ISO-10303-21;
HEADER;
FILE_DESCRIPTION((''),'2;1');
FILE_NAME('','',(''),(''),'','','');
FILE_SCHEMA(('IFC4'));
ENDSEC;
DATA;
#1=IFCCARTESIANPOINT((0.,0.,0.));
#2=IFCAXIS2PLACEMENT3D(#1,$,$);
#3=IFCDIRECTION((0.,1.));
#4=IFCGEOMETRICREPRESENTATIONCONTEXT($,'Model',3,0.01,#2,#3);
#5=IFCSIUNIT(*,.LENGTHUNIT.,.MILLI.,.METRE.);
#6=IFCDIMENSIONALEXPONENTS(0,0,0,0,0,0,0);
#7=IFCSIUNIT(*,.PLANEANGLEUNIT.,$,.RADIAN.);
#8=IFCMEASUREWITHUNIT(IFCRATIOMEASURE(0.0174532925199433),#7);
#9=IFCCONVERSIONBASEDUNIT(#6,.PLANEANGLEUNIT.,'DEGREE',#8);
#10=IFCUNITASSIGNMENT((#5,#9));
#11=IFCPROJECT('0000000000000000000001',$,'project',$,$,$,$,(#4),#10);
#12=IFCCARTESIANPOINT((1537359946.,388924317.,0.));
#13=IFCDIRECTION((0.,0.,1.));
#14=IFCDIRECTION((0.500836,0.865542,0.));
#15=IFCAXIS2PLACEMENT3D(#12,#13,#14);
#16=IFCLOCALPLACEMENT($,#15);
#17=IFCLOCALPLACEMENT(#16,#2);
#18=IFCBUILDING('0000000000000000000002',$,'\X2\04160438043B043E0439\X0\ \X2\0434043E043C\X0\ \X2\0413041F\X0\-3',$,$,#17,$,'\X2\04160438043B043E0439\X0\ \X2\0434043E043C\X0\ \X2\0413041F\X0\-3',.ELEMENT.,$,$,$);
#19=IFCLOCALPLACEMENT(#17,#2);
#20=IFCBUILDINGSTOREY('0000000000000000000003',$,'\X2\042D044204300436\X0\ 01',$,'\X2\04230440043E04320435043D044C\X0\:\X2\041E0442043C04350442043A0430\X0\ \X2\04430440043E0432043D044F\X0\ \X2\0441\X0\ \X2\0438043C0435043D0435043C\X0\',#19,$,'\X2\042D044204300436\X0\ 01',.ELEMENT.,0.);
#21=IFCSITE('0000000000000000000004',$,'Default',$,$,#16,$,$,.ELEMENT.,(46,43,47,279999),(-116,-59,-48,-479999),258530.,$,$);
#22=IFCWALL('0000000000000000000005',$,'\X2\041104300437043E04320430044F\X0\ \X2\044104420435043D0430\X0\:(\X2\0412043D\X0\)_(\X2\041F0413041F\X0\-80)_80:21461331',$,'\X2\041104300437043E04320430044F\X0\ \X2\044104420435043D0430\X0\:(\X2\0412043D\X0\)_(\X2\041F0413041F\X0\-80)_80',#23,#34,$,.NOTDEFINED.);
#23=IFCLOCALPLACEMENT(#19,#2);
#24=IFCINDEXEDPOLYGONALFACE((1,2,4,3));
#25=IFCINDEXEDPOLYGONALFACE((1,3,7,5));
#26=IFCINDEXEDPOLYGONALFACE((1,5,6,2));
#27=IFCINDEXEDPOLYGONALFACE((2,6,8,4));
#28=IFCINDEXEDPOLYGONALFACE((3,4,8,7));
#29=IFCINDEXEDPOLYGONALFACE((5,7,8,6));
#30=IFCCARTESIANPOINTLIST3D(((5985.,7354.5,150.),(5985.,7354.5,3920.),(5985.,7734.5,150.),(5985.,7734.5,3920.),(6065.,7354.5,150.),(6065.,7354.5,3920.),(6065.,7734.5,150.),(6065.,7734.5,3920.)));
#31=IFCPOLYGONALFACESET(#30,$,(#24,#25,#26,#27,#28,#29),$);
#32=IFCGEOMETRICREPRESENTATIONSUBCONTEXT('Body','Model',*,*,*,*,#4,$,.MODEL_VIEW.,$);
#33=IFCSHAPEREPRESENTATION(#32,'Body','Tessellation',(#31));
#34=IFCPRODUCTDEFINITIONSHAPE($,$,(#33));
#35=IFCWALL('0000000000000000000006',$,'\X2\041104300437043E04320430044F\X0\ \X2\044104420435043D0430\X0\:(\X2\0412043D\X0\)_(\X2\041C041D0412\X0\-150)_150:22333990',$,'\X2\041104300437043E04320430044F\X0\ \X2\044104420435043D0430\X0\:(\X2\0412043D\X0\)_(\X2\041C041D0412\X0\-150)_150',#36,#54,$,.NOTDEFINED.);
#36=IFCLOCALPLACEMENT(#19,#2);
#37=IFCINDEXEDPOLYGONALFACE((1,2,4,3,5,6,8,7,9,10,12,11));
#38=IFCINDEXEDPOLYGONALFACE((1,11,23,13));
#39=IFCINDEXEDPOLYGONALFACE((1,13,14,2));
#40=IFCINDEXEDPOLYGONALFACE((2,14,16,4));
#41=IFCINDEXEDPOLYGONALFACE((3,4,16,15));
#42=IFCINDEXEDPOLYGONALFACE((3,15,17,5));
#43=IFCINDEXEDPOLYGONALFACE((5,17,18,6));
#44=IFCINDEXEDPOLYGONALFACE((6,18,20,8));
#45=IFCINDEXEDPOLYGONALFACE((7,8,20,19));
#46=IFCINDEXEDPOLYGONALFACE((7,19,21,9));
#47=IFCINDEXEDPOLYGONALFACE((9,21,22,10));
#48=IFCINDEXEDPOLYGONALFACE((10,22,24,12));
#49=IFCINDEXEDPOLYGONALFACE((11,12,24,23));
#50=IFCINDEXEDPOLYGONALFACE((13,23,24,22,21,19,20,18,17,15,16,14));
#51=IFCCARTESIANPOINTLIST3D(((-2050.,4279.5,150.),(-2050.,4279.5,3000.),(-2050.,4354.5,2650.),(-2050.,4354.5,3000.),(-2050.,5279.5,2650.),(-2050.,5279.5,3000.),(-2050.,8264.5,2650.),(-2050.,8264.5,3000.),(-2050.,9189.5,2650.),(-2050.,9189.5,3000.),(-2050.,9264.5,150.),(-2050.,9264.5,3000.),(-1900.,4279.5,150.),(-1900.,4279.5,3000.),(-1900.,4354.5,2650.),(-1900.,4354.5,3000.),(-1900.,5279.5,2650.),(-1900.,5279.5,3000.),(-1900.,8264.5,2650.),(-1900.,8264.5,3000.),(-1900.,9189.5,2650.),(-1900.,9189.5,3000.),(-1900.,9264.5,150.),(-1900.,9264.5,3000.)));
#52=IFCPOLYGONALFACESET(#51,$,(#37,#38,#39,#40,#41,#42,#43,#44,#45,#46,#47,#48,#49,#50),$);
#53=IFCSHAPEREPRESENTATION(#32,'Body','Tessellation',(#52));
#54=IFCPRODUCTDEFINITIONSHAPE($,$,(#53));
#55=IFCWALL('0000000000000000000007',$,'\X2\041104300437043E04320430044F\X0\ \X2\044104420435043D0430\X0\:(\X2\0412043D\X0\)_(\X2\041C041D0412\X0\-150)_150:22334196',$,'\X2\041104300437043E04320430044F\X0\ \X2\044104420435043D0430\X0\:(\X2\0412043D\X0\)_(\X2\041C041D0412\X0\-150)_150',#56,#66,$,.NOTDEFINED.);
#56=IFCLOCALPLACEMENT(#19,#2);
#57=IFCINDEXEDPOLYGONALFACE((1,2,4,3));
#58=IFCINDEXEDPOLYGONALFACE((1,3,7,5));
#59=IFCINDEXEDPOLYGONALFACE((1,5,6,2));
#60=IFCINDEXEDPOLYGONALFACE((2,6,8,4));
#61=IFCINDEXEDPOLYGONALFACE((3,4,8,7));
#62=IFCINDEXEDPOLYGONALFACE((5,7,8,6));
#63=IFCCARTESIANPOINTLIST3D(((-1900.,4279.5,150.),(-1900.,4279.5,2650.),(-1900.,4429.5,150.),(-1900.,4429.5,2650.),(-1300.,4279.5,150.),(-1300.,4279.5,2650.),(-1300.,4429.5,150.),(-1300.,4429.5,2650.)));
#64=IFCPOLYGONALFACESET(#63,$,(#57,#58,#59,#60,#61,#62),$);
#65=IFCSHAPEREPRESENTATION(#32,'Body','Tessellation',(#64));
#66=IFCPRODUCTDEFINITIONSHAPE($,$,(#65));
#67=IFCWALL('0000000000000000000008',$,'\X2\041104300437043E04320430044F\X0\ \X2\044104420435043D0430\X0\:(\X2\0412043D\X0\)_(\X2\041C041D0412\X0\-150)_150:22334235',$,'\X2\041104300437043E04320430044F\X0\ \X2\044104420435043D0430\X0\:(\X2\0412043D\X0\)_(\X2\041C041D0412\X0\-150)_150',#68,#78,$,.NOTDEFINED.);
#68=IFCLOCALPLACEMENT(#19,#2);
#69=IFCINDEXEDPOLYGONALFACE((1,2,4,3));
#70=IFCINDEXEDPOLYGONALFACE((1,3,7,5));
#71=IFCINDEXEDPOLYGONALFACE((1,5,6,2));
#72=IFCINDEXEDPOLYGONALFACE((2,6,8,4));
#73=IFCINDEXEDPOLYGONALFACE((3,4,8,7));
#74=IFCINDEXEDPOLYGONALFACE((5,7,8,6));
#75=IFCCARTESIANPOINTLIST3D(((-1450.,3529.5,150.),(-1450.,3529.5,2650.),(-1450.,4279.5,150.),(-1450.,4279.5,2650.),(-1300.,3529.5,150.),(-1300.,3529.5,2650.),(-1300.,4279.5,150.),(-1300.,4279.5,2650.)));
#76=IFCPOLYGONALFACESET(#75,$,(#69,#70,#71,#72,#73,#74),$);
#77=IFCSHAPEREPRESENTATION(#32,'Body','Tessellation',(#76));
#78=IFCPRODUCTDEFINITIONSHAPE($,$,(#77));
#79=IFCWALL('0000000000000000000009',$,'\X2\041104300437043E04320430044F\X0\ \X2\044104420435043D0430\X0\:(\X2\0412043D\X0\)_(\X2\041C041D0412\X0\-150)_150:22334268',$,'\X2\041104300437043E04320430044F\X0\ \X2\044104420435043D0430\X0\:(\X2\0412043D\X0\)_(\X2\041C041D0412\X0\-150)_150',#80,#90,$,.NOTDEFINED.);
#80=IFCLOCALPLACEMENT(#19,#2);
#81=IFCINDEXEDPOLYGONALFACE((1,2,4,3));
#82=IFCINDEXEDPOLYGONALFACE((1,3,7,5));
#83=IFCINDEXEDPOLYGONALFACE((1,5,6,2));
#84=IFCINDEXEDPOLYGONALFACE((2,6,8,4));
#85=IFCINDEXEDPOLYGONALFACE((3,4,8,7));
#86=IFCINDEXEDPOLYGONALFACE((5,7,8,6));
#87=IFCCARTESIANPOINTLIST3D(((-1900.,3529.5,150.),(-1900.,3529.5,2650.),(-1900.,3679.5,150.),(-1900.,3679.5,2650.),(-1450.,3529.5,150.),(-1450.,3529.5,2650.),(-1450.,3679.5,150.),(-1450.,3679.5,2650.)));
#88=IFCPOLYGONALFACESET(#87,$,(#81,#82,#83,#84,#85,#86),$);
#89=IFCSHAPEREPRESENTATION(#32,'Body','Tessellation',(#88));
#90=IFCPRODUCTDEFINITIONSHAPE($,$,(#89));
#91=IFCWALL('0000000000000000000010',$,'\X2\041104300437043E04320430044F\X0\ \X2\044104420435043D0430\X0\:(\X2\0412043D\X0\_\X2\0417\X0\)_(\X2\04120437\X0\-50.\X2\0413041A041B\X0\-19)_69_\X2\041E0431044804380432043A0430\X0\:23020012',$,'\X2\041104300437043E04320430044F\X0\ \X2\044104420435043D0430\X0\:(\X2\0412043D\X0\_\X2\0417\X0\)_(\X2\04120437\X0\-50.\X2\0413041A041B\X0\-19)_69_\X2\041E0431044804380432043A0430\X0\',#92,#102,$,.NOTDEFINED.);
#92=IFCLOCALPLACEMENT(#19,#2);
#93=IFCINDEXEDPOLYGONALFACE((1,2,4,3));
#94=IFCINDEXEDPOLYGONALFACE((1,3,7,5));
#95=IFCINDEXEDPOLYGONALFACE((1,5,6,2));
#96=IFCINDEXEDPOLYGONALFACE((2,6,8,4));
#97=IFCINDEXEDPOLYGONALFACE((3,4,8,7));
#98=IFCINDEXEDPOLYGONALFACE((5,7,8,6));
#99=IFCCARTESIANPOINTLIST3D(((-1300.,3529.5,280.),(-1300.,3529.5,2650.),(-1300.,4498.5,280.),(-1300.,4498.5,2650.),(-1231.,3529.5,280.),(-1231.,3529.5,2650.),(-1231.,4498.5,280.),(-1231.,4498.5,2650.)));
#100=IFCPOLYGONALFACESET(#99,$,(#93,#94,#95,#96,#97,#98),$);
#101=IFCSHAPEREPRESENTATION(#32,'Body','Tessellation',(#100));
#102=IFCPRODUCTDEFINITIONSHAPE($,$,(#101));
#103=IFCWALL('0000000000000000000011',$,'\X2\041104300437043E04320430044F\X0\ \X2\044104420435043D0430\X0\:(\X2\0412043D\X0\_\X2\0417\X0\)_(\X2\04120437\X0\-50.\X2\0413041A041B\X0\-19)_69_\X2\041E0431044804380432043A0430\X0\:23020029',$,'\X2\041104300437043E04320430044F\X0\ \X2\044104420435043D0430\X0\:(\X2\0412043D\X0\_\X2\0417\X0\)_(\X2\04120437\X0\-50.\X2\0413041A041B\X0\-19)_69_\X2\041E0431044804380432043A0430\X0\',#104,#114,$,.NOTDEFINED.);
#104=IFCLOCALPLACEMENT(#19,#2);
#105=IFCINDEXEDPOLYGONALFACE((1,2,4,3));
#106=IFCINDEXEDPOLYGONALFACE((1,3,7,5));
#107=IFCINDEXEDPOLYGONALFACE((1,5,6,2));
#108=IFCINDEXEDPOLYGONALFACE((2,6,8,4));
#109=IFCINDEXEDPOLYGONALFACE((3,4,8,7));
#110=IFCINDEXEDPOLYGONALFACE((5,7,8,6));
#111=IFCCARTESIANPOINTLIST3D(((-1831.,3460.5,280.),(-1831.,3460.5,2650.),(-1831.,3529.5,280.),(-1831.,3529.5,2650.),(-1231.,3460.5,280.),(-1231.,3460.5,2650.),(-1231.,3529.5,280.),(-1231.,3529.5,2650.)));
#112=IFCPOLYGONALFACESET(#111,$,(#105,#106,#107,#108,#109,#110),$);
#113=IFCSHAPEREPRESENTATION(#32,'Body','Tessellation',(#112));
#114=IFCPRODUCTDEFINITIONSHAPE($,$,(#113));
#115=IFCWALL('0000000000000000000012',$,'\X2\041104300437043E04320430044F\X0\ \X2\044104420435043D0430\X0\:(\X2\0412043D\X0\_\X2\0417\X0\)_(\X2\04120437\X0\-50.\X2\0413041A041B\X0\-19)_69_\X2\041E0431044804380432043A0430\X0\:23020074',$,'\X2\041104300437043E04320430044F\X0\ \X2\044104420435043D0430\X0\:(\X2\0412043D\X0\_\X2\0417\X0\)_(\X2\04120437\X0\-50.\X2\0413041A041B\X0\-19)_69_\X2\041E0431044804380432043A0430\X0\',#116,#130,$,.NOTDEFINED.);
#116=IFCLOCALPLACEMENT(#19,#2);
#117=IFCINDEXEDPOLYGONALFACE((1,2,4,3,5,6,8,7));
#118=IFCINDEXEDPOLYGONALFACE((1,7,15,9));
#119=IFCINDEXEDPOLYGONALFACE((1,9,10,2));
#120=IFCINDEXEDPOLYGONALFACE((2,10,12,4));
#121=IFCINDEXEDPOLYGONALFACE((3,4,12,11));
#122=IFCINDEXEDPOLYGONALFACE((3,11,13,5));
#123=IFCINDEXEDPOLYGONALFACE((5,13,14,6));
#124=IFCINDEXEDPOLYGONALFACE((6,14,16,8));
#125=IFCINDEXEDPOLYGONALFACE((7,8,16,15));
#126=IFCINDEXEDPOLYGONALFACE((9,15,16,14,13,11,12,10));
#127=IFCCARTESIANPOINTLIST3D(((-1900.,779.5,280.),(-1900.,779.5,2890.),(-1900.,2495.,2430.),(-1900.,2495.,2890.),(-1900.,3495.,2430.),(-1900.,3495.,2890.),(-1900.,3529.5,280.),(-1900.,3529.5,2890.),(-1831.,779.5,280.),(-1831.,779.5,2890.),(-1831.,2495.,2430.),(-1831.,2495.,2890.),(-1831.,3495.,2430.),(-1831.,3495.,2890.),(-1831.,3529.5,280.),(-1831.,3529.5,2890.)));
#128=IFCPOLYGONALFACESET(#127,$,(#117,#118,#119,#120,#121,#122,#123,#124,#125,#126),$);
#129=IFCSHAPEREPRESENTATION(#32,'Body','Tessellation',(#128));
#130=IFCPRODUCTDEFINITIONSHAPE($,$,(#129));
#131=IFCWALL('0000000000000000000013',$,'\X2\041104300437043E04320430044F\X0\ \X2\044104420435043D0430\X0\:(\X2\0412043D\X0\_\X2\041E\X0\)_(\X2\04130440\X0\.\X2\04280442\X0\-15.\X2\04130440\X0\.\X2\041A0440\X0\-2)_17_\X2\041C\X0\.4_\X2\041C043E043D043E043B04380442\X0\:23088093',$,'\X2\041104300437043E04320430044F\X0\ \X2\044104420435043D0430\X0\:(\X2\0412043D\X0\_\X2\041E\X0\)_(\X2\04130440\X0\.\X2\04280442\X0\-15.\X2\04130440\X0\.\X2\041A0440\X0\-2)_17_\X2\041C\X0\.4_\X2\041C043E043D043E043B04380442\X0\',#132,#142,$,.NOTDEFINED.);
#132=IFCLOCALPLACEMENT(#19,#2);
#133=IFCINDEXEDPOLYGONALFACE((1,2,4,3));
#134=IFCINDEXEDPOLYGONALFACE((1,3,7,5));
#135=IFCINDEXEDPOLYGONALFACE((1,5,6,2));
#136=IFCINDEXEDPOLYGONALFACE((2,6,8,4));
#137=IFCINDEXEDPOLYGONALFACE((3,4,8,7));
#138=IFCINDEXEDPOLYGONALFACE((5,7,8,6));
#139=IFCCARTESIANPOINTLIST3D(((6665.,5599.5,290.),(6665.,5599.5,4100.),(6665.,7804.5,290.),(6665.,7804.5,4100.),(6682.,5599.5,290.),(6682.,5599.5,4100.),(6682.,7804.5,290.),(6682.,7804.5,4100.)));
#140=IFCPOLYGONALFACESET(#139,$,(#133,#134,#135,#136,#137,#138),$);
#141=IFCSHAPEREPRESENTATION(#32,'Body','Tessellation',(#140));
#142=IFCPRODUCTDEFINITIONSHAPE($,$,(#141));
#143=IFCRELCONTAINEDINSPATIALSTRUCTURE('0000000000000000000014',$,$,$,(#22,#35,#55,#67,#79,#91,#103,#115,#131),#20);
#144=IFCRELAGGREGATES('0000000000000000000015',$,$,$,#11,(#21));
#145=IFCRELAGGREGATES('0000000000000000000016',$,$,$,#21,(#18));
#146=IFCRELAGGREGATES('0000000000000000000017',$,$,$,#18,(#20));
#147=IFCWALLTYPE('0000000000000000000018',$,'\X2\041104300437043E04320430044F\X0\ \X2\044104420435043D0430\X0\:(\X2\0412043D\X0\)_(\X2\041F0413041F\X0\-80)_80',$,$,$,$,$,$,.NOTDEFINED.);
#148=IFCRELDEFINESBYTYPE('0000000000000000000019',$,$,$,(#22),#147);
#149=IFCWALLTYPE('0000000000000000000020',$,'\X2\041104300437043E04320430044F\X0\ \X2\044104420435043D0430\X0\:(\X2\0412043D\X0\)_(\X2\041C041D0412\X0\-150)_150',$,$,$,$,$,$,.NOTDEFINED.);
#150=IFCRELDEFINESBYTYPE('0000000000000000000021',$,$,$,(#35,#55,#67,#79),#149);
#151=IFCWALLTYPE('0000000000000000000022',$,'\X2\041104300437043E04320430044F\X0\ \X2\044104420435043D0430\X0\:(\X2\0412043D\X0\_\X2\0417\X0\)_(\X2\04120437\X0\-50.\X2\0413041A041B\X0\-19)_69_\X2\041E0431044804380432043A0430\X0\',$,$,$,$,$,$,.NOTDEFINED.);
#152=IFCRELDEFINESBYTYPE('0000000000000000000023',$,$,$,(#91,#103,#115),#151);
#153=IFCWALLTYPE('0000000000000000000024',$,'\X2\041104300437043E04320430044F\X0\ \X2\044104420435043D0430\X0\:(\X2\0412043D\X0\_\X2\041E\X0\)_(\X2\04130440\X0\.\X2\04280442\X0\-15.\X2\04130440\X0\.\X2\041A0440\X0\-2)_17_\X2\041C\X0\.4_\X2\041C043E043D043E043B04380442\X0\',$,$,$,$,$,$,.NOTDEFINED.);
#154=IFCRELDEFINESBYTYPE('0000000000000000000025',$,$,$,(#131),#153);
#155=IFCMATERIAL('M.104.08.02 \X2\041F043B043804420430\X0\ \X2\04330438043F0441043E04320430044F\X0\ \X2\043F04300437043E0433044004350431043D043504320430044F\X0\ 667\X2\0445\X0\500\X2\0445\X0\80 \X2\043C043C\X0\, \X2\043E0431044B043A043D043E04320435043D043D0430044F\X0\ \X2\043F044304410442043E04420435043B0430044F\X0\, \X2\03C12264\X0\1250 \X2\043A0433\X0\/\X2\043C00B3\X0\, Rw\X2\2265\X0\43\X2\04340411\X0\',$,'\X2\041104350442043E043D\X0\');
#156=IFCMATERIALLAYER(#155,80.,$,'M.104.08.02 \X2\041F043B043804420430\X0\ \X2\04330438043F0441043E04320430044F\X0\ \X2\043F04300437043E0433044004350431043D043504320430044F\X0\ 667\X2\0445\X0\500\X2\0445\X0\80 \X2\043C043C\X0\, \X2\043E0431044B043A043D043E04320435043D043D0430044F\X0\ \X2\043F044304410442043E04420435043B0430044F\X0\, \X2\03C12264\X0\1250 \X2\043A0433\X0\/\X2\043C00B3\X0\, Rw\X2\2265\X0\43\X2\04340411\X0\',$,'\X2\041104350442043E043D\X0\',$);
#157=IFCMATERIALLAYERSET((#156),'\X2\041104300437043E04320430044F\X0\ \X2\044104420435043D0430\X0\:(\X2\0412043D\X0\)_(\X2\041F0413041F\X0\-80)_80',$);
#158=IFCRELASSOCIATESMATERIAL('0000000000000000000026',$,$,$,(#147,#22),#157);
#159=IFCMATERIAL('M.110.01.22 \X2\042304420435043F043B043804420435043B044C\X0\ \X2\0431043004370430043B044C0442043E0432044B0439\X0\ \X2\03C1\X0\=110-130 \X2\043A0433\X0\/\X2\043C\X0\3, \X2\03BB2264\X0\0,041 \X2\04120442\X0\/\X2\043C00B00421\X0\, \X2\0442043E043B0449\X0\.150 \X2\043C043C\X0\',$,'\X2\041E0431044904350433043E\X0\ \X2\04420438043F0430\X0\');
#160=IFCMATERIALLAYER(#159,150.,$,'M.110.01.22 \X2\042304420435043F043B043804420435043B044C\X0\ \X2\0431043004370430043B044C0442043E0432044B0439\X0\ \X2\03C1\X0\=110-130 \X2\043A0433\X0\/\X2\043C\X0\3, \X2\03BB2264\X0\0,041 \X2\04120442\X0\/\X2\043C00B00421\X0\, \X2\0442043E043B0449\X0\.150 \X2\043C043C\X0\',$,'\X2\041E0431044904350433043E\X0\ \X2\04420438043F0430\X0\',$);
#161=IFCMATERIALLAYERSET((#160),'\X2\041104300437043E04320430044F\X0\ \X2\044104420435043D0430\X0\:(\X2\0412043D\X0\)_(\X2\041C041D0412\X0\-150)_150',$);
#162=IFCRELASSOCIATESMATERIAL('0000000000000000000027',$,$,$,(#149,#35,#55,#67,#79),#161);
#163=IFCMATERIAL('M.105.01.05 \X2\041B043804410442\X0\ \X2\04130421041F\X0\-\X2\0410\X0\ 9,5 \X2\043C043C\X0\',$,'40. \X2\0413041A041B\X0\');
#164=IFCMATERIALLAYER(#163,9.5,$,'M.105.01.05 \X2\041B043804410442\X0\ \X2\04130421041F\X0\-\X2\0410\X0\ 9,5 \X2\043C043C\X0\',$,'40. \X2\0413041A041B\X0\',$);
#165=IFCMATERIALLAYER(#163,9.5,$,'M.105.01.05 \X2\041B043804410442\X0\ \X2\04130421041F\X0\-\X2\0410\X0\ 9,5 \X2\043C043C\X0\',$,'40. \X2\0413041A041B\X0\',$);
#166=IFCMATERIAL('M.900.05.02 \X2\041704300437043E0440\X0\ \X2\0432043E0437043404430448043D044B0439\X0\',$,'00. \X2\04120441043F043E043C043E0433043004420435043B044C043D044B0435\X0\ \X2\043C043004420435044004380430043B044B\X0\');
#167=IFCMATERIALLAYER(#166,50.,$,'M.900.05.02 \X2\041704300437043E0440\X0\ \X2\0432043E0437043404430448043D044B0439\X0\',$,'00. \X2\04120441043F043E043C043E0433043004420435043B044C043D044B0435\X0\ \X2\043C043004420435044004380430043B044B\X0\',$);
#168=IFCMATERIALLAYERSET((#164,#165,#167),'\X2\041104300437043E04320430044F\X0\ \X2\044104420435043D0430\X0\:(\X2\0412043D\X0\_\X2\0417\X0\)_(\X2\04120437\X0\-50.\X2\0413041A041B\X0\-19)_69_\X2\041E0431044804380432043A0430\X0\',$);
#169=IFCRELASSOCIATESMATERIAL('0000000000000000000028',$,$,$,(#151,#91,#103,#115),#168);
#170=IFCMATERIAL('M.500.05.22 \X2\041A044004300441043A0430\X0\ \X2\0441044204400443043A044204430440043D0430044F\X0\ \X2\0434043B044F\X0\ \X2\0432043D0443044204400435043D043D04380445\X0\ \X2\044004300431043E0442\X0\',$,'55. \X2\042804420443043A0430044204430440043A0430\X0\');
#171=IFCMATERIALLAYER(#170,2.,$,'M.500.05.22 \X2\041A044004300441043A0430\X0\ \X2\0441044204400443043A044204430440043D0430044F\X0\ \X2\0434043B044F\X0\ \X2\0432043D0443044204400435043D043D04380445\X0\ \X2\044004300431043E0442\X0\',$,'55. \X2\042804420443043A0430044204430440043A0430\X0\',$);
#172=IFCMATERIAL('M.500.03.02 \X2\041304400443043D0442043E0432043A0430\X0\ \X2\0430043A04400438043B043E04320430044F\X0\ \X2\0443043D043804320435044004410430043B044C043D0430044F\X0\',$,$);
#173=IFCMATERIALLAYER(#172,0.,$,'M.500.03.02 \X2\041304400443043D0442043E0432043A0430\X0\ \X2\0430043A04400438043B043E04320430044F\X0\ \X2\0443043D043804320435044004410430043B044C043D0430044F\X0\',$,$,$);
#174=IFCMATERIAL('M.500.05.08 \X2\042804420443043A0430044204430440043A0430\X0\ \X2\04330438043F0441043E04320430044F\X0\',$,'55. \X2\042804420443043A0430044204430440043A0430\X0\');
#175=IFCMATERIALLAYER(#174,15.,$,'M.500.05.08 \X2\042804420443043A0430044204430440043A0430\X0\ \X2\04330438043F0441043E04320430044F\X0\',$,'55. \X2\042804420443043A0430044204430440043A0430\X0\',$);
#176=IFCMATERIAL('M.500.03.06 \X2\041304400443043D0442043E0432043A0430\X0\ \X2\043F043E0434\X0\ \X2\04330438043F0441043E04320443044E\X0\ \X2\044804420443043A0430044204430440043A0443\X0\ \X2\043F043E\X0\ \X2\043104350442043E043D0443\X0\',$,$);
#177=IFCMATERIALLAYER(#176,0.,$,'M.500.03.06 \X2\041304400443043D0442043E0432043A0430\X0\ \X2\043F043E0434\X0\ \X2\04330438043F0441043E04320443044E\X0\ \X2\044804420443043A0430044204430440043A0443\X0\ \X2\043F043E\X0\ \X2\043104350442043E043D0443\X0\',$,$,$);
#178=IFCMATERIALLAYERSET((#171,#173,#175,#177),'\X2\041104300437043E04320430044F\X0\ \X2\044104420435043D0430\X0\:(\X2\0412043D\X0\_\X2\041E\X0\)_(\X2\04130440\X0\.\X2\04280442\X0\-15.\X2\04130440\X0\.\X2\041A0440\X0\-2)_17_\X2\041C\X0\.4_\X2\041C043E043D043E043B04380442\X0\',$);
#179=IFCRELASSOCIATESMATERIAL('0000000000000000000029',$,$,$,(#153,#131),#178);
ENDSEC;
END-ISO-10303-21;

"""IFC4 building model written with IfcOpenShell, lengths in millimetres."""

from ifc_helpers import new_model, entity, si_unit, converted_unit, direction, frame, frame_2d, origin, place, context, subcontext, project, spatial, rectangle, extrude, material, layer, layer_set, layer_usage, type_object, element, save


model = new_model("IFC4")

# Units and contexts
model_context = context("Model", 3, precision=0.01, world=origin(), true_north=direction((0.0, 1.0)))
body_context = subcontext(model_context, "Body", "Model", "MODEL_VIEW")
ifc_project = project(units=[si_unit("LENGTHUNIT", "METRE", prefix="MILLI"), converted_unit("PLANEANGLEUNIT", "DEGREE", entity("IfcRatioMeasure", 0.0174532925199433), si_unit("PLANEANGLEUNIT", "RADIAN"), dimensions=[0, 0, 0, 0, 0, 0, 0])], contexts=[model_context])

# Site, building, storey
site_placement = place(None, frame((1537359946.0, 388924317.0, 0.0), z_axis=(0.0, 0.0, 1.0), x_axis=(0.500836, 0.865542, 0.0)))
site = spatial("IfcSite", under=ifc_project, at=site_placement, Name="Default", CompositionType="ELEMENT", RefLatitude=(46, 43, 47, 279999), RefLongitude=(-116, -59, -48, -479999), RefElevation=258530.0)
building_placement = place(site_placement, origin())
building = spatial("IfcBuilding", under=site, at=building_placement, Name="Жилой дом ГП-3", LongName="Жилой дом ГП-3", CompositionType="ELEMENT")
storey_placement = place(building_placement, origin())
storey = spatial("IfcBuildingStorey", under=building, at=storey_placement, Name="Этаж 01", ObjectType="Уровень:Отметка уровня с именем", LongName="Этаж 01", CompositionType="ELEMENT", Elevation=0.0)

# Wall
ifc_material_1 = material(Name="M.900.05.02 Зазор воздушный", Category="00. Вспомогательные материалы")
ifc_material_2 = material(Name="M.104.08.02 Плита гипсовая пазогребневая 667х500х80 мм, обыкновенная пустотелая, ρ≤1250 кг/м³, Rw≥43дБ", Category="Бетон")
ifc_layer_1 = layer(ifc_material_2, 80.0, Name="M.104.08.02 Плита гипсовая пазогребневая 667х500х80 мм, обыкновенная пустотелая, ρ≤1250 кг/м³, Rw≥43дБ", Category="Бетон")
ifc_layer_set_1 = layer_set([ifc_layer_1], Name="Базовая стена:(Вн)_(ПГП-80)_80")
wall_type_1 = type_object("IfcWallType", Name="Базовая стена:(Вн)_(ПГП-80)_80", PredefinedType="NOTDEFINED", material=ifc_layer_set_1)
ifc_layer_usage_1 = layer_usage(ifc_layer_set_1, "AXIS2", "NEGATIVE", 40.0)
wall_1_placement = place(storey_placement, frame((6025.0, 7734.5, 150.0), z_axis=(0.0, 0.0, 1.0), x_axis=(0.0, -1.0, 0.0)))
element("IfcWall", 1, at=wall_1_placement, inside=storey, type_object=wall_type_1, material=ifc_layer_usage_1, Name="Базовая стена:(Вн)_(ПГП-80)_80:21461331", ObjectType="Базовая стена:(Вн)_(ПГП-80)_80", PredefinedType="NOTDEFINED", context=body_context, shape_type="SweptSolid", body=[
    extrude(rectangle(XDim=380.0, YDim=80.0, at=frame_2d((190.0, 0.0), x_axis=(-1.0, 0.0))), origin(), (0.0, 0.0, 1.0), 3770.0),
])

# Wall, openings
ifc_material_3 = material(Name="M.110.01.22 Утеплитель базальтовый ρ=110-130 кг/м3, λ≤0,041 Вт/м°С, толщ.150 мм", Category="Общего типа")
ifc_layer_2 = layer(ifc_material_3, 150.0, Name="M.110.01.22 Утеплитель базальтовый ρ=110-130 кг/м3, λ≤0,041 Вт/м°С, толщ.150 мм", Category="Общего типа")
ifc_layer_set_2 = layer_set([ifc_layer_2], Name="Базовая стена:(Вн)_(МНВ-150)_150")
ifc_layer_usage_2 = layer_usage(ifc_layer_set_2, "AXIS2", "POSITIVE", -75.0)
wall_type_2 = type_object("IfcWallType", Name="Базовая стена:(Вн)_(МНВ-150)_150", PredefinedType="NOTDEFINED", material=ifc_layer_set_2)
wall_2_placement = place(storey_placement, frame((-1975.0, 4279.5, 150.0), z_axis=(0.0, 0.0, 1.0), x_axis=(0.0, 1.0, 0.0)))
wall_2 = element("IfcWall", 2, at=wall_2_placement, inside=storey, type_object=wall_type_2, material=ifc_layer_usage_2, Name="Базовая стена:(Вн)_(МНВ-150)_150:22333990", ObjectType="Базовая стена:(Вн)_(МНВ-150)_150", PredefinedType="NOTDEFINED", context=body_context, shape_type="SweptSolid", body=[
    extrude(rectangle(XDim=4985.0, YDim=150.0, at=frame_2d((2492.5, 0.0), x_axis=(-1.0, 0.0))), origin(), (0.0, 0.0, 1.0), 2850.0),
])
opening_1_placement = place(wall_2_placement, origin())
element("IfcOpeningElement", 3, at=opening_1_placement, cuts=wall_2, ObjectType="Opening", PredefinedType="OPENING", context=body_context, shape_type="SweptSolid", body=[
    extrude(rectangle(XDim=350.0, YDim=925.0, at=frame_2d((0.0, 0.0), x_axis=(1.0, 0.0))), frame((4447.5, 75.0, 2675.0), z_axis=(0.0, -1.0, 0.0), x_axis=(0.0, 0.0, 1.0)), (0.0, 0.0, 1.0), 150.0),
])
opening_2_placement = place(wall_2_placement, origin())
element("IfcOpeningElement", 4, at=opening_2_placement, cuts=wall_2, ObjectType="Opening", PredefinedType="OPENING", context=body_context, shape_type="SweptSolid", body=[
    extrude(rectangle(XDim=350.0, YDim=925.0, at=frame_2d((0.0, 0.0), x_axis=(0.0, 1.0))), frame((537.5, 75.0, 2675.0), z_axis=(0.0, -1.0, 0.0), x_axis=(-1.0, 0.0, 0.0)), (0.0, 0.0, 1.0), 150.0),
])

# Walls
ifc_layer_usage_3 = layer_usage(ifc_layer_set_2, "AXIS2", "NEGATIVE", 75.0)
wall_3_placement = place(storey_placement, frame((-1900.0, 4354.5, 150.0)))
element("IfcWall", 5, at=wall_3_placement, inside=storey, type_object=wall_type_2, material=ifc_layer_usage_3, Name="Базовая стена:(Вн)_(МНВ-150)_150:22334196", ObjectType="Базовая стена:(Вн)_(МНВ-150)_150", PredefinedType="NOTDEFINED", context=body_context, shape_type="SweptSolid", body=[
    extrude(rectangle(XDim=600.0, YDim=150.0, at=frame_2d((300.0, 0.0), x_axis=(-1.0, 0.0))), origin(), (0.0, 0.0, 1.0), 2500.0),
])
ifc_layer_usage_4 = layer_usage(ifc_layer_set_2, "AXIS2", "NEGATIVE", 75.0)
wall_4_placement = place(storey_placement, frame((-1375.0, 4279.5, 150.0), z_axis=(0.0, 0.0, 1.0), x_axis=(0.0, -1.0, 0.0)))
element("IfcWall", 6, at=wall_4_placement, inside=storey, type_object=wall_type_2, material=ifc_layer_usage_4, Name="Базовая стена:(Вн)_(МНВ-150)_150:22334235", ObjectType="Базовая стена:(Вн)_(МНВ-150)_150", PredefinedType="NOTDEFINED", context=body_context, shape_type="SweptSolid", body=[
    extrude(rectangle(XDim=750.0, YDim=150.0, at=frame_2d((375.0, 0.0), x_axis=(-1.0, 0.0))), origin(), (0.0, 0.0, 1.0), 2500.0),
])
ifc_layer_usage_5 = layer_usage(ifc_layer_set_2, "AXIS2", "NEGATIVE", 75.0)
wall_5_placement = place(storey_placement, frame((-1450.0, 3604.5, 150.0), z_axis=(0.0, 0.0, 1.0), x_axis=(-1.0, 0.0, 0.0)))
element("IfcWall", 7, at=wall_5_placement, inside=storey, type_object=wall_type_2, material=ifc_layer_usage_5, Name="Базовая стена:(Вн)_(МНВ-150)_150:22334268", ObjectType="Базовая стена:(Вн)_(МНВ-150)_150", PredefinedType="NOTDEFINED", context=body_context, shape_type="SweptSolid", body=[
    extrude(rectangle(XDim=450.0, YDim=150.0, at=frame_2d((225.0, 0.0), x_axis=(-1.0, 0.0))), origin(), (0.0, 0.0, 1.0), 2500.0),
])
ifc_material_4 = material(Name="M.105.01.05 Лист ГСП-А 9,5 мм", Category="40. ГКЛ")
ifc_layer_3 = layer(ifc_material_4, 9.5, Name="M.105.01.05 Лист ГСП-А 9,5 мм", Category="40. ГКЛ")
ifc_layer_4 = layer(ifc_material_4, 9.5, Name="M.105.01.05 Лист ГСП-А 9,5 мм", Category="40. ГКЛ")
ifc_layer_5 = layer(ifc_material_1, 50.0, Name="M.900.05.02 Зазор воздушный", Category="00. Вспомогательные материалы")
ifc_layer_set_3 = layer_set([ifc_layer_3, ifc_layer_4, ifc_layer_5], Name="Базовая стена:(Вн_З)_(Вз-50.ГКЛ-19)_69_Обшивка")
ifc_layer_usage_6 = layer_usage(ifc_layer_set_3, "AXIS2", "NEGATIVE", 34.5)
wall_type_3 = type_object("IfcWallType", Name="Базовая стена:(Вн_З)_(Вз-50.ГКЛ-19)_69_Обшивка", PredefinedType="NOTDEFINED", material=ifc_layer_set_3)
wall_6_placement = place(storey_placement, frame((-1265.5, 4498.5, 280.0), z_axis=(0.0, 0.0, 1.0), x_axis=(0.0, -1.0, 0.0)))
element("IfcWall", 8, at=wall_6_placement, inside=storey, type_object=wall_type_3, material=ifc_layer_usage_6, Name="Базовая стена:(Вн_З)_(Вз-50.ГКЛ-19)_69_Обшивка:23020012", ObjectType="Базовая стена:(Вн_З)_(Вз-50.ГКЛ-19)_69_Обшивка", PredefinedType="NOTDEFINED", context=body_context, shape_type="SweptSolid", body=[
    extrude(rectangle(XDim=969.0, YDim=69.0, at=frame_2d((484.5, 0.0), x_axis=(-1.0, 0.0))), origin(), (0.0, 0.0, 1.0), 2370.0),
])
ifc_layer_usage_7 = layer_usage(ifc_layer_set_3, "AXIS2", "NEGATIVE", 34.5)
wall_7_placement = place(storey_placement, frame((-1231.0, 3495.0, 280.0), z_axis=(0.0, 0.0, 1.0), x_axis=(-1.0, 0.0, 0.0)))
element("IfcWall", 9, at=wall_7_placement, inside=storey, type_object=wall_type_3, material=ifc_layer_usage_7, Name="Базовая стена:(Вн_З)_(Вз-50.ГКЛ-19)_69_Обшивка:23020029", ObjectType="Базовая стена:(Вн_З)_(Вз-50.ГКЛ-19)_69_Обшивка", PredefinedType="NOTDEFINED", context=body_context, shape_type="SweptSolid", body=[
    extrude(rectangle(XDim=600.0, YDim=69.0, at=frame_2d((300.0, 0.0), x_axis=(-1.0, 0.0))), origin(), (0.0, 0.0, 1.0), 2370.0),
])

# Wall, opening
ifc_layer_usage_8 = layer_usage(ifc_layer_set_3, "AXIS2", "NEGATIVE", 34.5)
wall_8_placement = place(storey_placement, frame((-1865.5, 3529.5, 280.0), z_axis=(0.0, 0.0, 1.0), x_axis=(0.0, -1.0, 0.0)))
wall_8 = element("IfcWall", 10, at=wall_8_placement, inside=storey, type_object=wall_type_3, material=ifc_layer_usage_8, Name="Базовая стена:(Вн_З)_(Вз-50.ГКЛ-19)_69_Обшивка:23020074", ObjectType="Базовая стена:(Вн_З)_(Вз-50.ГКЛ-19)_69_Обшивка", PredefinedType="NOTDEFINED", context=body_context, shape_type="SweptSolid", body=[
    extrude(rectangle(XDim=2750.0, YDim=69.0, at=frame_2d((1375.0, 0.0), x_axis=(-1.0, 0.0))), origin(), (0.0, 0.0, 1.0), 2610.0),
])
opening_3_placement = place(wall_8_placement, origin())
element("IfcOpeningElement", 11, at=opening_3_placement, cuts=wall_8, ObjectType="Opening", PredefinedType="OPENING", context=body_context, shape_type="SweptSolid", body=[
    extrude(rectangle(XDim=460.0, YDim=1000.0, at=frame_2d((0.0, 0.0), x_axis=(0.0, 1.0))), frame((534.5, 34.5, 2380.0), z_axis=(0.0, -1.0, 0.0), x_axis=(-1.0, 0.0, 0.0)), (0.0, 0.0, 1.0), 69.0),
])

# Wall
ifc_material_5 = material(Name="M.500.05.22 Краска структурная для внутренних работ", Category="55. Штукатурка")
ifc_layer_6 = layer(ifc_material_5, 2.0, Name="M.500.05.22 Краска структурная для внутренних работ", Category="55. Штукатурка")
ifc_material_6 = material(Name="M.500.03.02 Грунтовка акриловая универсальная")
ifc_layer_7 = layer(ifc_material_6, 0.0, Name="M.500.03.02 Грунтовка акриловая универсальная")
ifc_material_7 = material(Name="M.500.05.08 Штукатурка гипсовая", Category="55. Штукатурка")
ifc_layer_8 = layer(ifc_material_7, 15.0, Name="M.500.05.08 Штукатурка гипсовая", Category="55. Штукатурка")
ifc_material_8 = material(Name="M.500.03.06 Грунтовка под гипсовую штукатурку по бетону")
ifc_layer_9 = layer(ifc_material_8, 0.0, Name="M.500.03.06 Грунтовка под гипсовую штукатурку по бетону")
ifc_layer_set_4 = layer_set([ifc_layer_6, ifc_layer_7, ifc_layer_8, ifc_layer_9], Name="Базовая стена:(Вн_О)_(Гр.Шт-15.Гр.Кр-2)_17_М.4_Монолит")
ifc_layer_usage_9 = layer_usage(ifc_layer_set_4, "AXIS2", "NEGATIVE", 8.5)
wall_type_4 = type_object("IfcWallType", Name="Базовая стена:(Вн_О)_(Гр.Шт-15.Гр.Кр-2)_17_М.4_Монолит", PredefinedType="NOTDEFINED", material=ifc_layer_set_4)
wall_9_placement = place(storey_placement, frame((6673.5, 7804.5, 290.0), z_axis=(0.0, 0.0, 1.0), x_axis=(0.0, -1.0, 0.0)))
element("IfcWall", 12, at=wall_9_placement, inside=storey, type_object=wall_type_4, material=ifc_layer_usage_9, Name="Базовая стена:(Вн_О)_(Гр.Шт-15.Гр.Кр-2)_17_М.4_Монолит:23088093", ObjectType="Базовая стена:(Вн_О)_(Гр.Шт-15.Гр.Кр-2)_17_М.4_Монолит", PredefinedType="NOTDEFINED", context=body_context, shape_type="SweptSolid", body=[
    extrude(rectangle(XDim=2205.0, YDim=17.0, at=frame_2d((1102.5, 0.0), x_axis=(-1.0, 0.0))), origin(), (0.0, 0.0, 1.0), 3810.0),
])

save(model, "model.ifc")
